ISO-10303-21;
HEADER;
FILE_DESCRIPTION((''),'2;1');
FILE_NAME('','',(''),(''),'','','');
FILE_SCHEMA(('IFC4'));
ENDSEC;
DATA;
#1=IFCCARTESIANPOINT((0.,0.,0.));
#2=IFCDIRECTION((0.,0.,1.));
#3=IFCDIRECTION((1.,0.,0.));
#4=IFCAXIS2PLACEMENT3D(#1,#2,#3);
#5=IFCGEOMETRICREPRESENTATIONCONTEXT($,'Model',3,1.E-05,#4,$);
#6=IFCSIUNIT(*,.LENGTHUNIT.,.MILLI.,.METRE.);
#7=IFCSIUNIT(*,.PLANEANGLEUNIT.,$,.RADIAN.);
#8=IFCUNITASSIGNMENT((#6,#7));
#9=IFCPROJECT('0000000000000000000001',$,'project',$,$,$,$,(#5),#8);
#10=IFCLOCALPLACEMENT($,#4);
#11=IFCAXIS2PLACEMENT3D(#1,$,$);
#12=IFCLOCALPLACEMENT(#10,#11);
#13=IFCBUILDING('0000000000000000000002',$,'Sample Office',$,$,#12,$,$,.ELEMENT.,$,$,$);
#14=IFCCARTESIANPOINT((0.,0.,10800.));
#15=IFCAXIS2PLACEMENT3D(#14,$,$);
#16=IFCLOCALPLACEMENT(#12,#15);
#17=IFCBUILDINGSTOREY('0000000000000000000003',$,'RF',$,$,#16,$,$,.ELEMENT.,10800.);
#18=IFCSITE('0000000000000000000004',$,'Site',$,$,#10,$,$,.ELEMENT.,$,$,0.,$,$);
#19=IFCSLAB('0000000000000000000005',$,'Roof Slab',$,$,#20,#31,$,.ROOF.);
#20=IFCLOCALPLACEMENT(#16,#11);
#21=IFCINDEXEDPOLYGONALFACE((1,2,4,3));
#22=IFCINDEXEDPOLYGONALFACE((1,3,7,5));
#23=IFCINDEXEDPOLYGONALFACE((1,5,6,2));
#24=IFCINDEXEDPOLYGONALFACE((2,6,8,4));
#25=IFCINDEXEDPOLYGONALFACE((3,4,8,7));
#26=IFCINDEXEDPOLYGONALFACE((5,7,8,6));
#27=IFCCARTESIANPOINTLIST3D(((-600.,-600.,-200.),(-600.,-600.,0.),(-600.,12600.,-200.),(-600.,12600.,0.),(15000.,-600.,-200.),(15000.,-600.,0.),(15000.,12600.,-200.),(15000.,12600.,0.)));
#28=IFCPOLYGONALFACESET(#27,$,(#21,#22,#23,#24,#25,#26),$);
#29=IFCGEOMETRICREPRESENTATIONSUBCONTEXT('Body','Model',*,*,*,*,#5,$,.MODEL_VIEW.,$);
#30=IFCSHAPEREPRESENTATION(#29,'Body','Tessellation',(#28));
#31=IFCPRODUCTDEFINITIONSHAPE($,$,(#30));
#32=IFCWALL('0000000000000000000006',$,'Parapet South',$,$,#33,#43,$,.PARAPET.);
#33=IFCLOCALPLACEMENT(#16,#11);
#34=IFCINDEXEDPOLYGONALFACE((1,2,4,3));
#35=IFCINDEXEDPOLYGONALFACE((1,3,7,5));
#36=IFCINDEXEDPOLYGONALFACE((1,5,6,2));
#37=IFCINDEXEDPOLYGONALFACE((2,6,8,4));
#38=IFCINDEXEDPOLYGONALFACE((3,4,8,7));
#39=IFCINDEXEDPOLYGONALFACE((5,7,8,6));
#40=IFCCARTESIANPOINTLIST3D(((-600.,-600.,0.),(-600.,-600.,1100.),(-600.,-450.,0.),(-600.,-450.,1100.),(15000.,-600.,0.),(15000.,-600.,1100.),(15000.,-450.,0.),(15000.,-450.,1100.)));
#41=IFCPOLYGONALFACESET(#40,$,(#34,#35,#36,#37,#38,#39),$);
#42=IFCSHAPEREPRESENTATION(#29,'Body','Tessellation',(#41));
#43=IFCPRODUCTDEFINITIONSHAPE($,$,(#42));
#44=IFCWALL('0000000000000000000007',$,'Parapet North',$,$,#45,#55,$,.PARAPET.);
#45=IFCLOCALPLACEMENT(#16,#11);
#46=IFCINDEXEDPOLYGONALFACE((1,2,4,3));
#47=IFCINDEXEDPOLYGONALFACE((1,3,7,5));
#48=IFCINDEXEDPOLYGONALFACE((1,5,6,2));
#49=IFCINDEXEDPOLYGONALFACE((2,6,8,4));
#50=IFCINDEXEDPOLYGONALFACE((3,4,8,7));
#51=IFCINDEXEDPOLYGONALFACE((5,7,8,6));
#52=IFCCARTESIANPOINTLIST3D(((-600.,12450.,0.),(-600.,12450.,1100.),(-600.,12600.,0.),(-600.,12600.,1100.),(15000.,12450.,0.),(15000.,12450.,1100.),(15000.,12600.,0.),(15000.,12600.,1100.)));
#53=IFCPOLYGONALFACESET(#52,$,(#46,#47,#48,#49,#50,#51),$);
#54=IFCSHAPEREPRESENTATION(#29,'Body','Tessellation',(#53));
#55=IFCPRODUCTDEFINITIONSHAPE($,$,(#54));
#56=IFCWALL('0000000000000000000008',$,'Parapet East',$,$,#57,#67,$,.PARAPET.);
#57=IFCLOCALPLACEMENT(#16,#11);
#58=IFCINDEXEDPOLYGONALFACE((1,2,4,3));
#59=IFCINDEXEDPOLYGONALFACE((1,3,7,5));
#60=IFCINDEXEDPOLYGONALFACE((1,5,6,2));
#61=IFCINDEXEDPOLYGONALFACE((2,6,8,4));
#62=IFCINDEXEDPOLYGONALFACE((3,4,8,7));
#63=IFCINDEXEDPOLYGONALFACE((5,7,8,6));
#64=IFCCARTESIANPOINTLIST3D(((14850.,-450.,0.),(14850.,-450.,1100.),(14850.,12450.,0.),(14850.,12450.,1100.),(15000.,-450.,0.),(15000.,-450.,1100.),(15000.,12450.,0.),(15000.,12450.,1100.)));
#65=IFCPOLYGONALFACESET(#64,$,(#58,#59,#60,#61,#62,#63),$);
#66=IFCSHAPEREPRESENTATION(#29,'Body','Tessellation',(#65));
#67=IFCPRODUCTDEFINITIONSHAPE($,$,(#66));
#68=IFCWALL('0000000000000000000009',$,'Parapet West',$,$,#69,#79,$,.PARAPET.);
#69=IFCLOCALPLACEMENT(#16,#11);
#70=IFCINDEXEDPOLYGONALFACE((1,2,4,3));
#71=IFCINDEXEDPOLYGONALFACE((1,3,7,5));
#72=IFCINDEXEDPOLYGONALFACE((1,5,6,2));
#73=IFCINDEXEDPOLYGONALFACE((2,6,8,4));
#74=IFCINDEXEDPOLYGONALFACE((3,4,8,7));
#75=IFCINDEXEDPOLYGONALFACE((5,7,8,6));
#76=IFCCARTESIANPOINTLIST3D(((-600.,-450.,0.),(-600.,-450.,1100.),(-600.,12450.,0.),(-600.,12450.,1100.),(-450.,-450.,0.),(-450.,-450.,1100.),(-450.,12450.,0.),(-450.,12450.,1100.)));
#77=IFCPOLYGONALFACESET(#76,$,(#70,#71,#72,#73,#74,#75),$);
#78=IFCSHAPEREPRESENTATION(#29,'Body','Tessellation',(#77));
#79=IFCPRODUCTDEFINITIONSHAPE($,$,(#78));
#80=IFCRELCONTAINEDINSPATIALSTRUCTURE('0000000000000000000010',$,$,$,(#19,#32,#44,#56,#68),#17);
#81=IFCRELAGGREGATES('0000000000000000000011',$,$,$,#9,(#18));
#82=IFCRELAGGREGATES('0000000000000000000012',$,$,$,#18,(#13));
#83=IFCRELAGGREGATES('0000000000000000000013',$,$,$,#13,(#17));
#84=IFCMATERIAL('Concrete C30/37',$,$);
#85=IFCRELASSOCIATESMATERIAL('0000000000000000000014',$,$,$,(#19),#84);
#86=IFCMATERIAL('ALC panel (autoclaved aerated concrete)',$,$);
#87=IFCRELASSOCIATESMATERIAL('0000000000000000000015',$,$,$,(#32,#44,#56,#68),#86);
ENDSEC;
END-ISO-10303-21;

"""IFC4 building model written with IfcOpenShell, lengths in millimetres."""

from ifc_helpers import new_model, si_unit, frame, origin, origin_with_axes, origin_2d, place, context, subcontext, project, spatial, rectangle, extrude, material, element, save


model = new_model("IFC4")

# Units and contexts
model_context = context("Model", 3, precision=1e-05, world=origin_with_axes())
body_context = subcontext(model_context, "Body", "Model", "MODEL_VIEW")
ifc_project = project(units=[si_unit("LENGTHUNIT", "METRE", prefix="MILLI"), si_unit("PLANEANGLEUNIT", "RADIAN")], contexts=[model_context])

# Site, building, storey
site_placement = place(None, origin_with_axes())
site = spatial("IfcSite", under=ifc_project, at=site_placement, Name="Site", CompositionType="ELEMENT", RefElevation=0.0)
building_placement = place(site_placement, origin())
building = spatial("IfcBuilding", under=site, at=building_placement, Name="Sample Office", CompositionType="ELEMENT")
storey_placement = place(building_placement, frame((0.0, 0.0, 10800.0)))
storey = spatial("IfcBuildingStorey", under=building, at=storey_placement, Name="RF", CompositionType="ELEMENT", Elevation=10800.0)

# Slab
ifc_material_1 = material(Name="Concrete C30/37")
slab_placement = place(storey_placement, frame((7200.0, 6000.0, -200.0)))
element("IfcSlab", 1, at=slab_placement, inside=storey, material=ifc_material_1, Name="Roof Slab", PredefinedType="ROOF", context=body_context, shape_type="SweptSolid", body=[
    extrude(rectangle(XDim=15600.0, YDim=13200.0, at=origin_2d()), origin(), (0.0, 0.0, 1.0), 200.0),
])

# Walls
ifc_material_2 = material(Name="ALC panel (autoclaved aerated concrete)")
for number, where, name in (
    (2, (7200.0, -525.0, 0.0), "Parapet South"),
    (3, (7200.0, 12525.0, 0.0), "Parapet North"),
):
    element("IfcWall", number, at=place(storey_placement, frame(where)), inside=storey, material=ifc_material_2, Name=name, PredefinedType="PARAPET", context=body_context, shape_type="SweptSolid", body=[
        extrude(rectangle(XDim=15600.0, YDim=150.0, at=origin_2d()), origin(), (0.0, 0.0, 1.0), 1100.0),
    ])
for number, where, name in (
    (4, (14925.0, 6000.0, 0.0), "Parapet East"),
    (5, (-525.0, 6000.0, 0.0), "Parapet West"),
):
    element("IfcWall", number, at=place(storey_placement, frame(where)), inside=storey, material=ifc_material_2, Name=name, PredefinedType="PARAPET", context=body_context, shape_type="SweptSolid", body=[
        extrude(rectangle(XDim=150.0, YDim=12900.0, at=origin_2d()), origin(), (0.0, 0.0, 1.0), 1100.0),
    ])

save(model, "model.ifc")
